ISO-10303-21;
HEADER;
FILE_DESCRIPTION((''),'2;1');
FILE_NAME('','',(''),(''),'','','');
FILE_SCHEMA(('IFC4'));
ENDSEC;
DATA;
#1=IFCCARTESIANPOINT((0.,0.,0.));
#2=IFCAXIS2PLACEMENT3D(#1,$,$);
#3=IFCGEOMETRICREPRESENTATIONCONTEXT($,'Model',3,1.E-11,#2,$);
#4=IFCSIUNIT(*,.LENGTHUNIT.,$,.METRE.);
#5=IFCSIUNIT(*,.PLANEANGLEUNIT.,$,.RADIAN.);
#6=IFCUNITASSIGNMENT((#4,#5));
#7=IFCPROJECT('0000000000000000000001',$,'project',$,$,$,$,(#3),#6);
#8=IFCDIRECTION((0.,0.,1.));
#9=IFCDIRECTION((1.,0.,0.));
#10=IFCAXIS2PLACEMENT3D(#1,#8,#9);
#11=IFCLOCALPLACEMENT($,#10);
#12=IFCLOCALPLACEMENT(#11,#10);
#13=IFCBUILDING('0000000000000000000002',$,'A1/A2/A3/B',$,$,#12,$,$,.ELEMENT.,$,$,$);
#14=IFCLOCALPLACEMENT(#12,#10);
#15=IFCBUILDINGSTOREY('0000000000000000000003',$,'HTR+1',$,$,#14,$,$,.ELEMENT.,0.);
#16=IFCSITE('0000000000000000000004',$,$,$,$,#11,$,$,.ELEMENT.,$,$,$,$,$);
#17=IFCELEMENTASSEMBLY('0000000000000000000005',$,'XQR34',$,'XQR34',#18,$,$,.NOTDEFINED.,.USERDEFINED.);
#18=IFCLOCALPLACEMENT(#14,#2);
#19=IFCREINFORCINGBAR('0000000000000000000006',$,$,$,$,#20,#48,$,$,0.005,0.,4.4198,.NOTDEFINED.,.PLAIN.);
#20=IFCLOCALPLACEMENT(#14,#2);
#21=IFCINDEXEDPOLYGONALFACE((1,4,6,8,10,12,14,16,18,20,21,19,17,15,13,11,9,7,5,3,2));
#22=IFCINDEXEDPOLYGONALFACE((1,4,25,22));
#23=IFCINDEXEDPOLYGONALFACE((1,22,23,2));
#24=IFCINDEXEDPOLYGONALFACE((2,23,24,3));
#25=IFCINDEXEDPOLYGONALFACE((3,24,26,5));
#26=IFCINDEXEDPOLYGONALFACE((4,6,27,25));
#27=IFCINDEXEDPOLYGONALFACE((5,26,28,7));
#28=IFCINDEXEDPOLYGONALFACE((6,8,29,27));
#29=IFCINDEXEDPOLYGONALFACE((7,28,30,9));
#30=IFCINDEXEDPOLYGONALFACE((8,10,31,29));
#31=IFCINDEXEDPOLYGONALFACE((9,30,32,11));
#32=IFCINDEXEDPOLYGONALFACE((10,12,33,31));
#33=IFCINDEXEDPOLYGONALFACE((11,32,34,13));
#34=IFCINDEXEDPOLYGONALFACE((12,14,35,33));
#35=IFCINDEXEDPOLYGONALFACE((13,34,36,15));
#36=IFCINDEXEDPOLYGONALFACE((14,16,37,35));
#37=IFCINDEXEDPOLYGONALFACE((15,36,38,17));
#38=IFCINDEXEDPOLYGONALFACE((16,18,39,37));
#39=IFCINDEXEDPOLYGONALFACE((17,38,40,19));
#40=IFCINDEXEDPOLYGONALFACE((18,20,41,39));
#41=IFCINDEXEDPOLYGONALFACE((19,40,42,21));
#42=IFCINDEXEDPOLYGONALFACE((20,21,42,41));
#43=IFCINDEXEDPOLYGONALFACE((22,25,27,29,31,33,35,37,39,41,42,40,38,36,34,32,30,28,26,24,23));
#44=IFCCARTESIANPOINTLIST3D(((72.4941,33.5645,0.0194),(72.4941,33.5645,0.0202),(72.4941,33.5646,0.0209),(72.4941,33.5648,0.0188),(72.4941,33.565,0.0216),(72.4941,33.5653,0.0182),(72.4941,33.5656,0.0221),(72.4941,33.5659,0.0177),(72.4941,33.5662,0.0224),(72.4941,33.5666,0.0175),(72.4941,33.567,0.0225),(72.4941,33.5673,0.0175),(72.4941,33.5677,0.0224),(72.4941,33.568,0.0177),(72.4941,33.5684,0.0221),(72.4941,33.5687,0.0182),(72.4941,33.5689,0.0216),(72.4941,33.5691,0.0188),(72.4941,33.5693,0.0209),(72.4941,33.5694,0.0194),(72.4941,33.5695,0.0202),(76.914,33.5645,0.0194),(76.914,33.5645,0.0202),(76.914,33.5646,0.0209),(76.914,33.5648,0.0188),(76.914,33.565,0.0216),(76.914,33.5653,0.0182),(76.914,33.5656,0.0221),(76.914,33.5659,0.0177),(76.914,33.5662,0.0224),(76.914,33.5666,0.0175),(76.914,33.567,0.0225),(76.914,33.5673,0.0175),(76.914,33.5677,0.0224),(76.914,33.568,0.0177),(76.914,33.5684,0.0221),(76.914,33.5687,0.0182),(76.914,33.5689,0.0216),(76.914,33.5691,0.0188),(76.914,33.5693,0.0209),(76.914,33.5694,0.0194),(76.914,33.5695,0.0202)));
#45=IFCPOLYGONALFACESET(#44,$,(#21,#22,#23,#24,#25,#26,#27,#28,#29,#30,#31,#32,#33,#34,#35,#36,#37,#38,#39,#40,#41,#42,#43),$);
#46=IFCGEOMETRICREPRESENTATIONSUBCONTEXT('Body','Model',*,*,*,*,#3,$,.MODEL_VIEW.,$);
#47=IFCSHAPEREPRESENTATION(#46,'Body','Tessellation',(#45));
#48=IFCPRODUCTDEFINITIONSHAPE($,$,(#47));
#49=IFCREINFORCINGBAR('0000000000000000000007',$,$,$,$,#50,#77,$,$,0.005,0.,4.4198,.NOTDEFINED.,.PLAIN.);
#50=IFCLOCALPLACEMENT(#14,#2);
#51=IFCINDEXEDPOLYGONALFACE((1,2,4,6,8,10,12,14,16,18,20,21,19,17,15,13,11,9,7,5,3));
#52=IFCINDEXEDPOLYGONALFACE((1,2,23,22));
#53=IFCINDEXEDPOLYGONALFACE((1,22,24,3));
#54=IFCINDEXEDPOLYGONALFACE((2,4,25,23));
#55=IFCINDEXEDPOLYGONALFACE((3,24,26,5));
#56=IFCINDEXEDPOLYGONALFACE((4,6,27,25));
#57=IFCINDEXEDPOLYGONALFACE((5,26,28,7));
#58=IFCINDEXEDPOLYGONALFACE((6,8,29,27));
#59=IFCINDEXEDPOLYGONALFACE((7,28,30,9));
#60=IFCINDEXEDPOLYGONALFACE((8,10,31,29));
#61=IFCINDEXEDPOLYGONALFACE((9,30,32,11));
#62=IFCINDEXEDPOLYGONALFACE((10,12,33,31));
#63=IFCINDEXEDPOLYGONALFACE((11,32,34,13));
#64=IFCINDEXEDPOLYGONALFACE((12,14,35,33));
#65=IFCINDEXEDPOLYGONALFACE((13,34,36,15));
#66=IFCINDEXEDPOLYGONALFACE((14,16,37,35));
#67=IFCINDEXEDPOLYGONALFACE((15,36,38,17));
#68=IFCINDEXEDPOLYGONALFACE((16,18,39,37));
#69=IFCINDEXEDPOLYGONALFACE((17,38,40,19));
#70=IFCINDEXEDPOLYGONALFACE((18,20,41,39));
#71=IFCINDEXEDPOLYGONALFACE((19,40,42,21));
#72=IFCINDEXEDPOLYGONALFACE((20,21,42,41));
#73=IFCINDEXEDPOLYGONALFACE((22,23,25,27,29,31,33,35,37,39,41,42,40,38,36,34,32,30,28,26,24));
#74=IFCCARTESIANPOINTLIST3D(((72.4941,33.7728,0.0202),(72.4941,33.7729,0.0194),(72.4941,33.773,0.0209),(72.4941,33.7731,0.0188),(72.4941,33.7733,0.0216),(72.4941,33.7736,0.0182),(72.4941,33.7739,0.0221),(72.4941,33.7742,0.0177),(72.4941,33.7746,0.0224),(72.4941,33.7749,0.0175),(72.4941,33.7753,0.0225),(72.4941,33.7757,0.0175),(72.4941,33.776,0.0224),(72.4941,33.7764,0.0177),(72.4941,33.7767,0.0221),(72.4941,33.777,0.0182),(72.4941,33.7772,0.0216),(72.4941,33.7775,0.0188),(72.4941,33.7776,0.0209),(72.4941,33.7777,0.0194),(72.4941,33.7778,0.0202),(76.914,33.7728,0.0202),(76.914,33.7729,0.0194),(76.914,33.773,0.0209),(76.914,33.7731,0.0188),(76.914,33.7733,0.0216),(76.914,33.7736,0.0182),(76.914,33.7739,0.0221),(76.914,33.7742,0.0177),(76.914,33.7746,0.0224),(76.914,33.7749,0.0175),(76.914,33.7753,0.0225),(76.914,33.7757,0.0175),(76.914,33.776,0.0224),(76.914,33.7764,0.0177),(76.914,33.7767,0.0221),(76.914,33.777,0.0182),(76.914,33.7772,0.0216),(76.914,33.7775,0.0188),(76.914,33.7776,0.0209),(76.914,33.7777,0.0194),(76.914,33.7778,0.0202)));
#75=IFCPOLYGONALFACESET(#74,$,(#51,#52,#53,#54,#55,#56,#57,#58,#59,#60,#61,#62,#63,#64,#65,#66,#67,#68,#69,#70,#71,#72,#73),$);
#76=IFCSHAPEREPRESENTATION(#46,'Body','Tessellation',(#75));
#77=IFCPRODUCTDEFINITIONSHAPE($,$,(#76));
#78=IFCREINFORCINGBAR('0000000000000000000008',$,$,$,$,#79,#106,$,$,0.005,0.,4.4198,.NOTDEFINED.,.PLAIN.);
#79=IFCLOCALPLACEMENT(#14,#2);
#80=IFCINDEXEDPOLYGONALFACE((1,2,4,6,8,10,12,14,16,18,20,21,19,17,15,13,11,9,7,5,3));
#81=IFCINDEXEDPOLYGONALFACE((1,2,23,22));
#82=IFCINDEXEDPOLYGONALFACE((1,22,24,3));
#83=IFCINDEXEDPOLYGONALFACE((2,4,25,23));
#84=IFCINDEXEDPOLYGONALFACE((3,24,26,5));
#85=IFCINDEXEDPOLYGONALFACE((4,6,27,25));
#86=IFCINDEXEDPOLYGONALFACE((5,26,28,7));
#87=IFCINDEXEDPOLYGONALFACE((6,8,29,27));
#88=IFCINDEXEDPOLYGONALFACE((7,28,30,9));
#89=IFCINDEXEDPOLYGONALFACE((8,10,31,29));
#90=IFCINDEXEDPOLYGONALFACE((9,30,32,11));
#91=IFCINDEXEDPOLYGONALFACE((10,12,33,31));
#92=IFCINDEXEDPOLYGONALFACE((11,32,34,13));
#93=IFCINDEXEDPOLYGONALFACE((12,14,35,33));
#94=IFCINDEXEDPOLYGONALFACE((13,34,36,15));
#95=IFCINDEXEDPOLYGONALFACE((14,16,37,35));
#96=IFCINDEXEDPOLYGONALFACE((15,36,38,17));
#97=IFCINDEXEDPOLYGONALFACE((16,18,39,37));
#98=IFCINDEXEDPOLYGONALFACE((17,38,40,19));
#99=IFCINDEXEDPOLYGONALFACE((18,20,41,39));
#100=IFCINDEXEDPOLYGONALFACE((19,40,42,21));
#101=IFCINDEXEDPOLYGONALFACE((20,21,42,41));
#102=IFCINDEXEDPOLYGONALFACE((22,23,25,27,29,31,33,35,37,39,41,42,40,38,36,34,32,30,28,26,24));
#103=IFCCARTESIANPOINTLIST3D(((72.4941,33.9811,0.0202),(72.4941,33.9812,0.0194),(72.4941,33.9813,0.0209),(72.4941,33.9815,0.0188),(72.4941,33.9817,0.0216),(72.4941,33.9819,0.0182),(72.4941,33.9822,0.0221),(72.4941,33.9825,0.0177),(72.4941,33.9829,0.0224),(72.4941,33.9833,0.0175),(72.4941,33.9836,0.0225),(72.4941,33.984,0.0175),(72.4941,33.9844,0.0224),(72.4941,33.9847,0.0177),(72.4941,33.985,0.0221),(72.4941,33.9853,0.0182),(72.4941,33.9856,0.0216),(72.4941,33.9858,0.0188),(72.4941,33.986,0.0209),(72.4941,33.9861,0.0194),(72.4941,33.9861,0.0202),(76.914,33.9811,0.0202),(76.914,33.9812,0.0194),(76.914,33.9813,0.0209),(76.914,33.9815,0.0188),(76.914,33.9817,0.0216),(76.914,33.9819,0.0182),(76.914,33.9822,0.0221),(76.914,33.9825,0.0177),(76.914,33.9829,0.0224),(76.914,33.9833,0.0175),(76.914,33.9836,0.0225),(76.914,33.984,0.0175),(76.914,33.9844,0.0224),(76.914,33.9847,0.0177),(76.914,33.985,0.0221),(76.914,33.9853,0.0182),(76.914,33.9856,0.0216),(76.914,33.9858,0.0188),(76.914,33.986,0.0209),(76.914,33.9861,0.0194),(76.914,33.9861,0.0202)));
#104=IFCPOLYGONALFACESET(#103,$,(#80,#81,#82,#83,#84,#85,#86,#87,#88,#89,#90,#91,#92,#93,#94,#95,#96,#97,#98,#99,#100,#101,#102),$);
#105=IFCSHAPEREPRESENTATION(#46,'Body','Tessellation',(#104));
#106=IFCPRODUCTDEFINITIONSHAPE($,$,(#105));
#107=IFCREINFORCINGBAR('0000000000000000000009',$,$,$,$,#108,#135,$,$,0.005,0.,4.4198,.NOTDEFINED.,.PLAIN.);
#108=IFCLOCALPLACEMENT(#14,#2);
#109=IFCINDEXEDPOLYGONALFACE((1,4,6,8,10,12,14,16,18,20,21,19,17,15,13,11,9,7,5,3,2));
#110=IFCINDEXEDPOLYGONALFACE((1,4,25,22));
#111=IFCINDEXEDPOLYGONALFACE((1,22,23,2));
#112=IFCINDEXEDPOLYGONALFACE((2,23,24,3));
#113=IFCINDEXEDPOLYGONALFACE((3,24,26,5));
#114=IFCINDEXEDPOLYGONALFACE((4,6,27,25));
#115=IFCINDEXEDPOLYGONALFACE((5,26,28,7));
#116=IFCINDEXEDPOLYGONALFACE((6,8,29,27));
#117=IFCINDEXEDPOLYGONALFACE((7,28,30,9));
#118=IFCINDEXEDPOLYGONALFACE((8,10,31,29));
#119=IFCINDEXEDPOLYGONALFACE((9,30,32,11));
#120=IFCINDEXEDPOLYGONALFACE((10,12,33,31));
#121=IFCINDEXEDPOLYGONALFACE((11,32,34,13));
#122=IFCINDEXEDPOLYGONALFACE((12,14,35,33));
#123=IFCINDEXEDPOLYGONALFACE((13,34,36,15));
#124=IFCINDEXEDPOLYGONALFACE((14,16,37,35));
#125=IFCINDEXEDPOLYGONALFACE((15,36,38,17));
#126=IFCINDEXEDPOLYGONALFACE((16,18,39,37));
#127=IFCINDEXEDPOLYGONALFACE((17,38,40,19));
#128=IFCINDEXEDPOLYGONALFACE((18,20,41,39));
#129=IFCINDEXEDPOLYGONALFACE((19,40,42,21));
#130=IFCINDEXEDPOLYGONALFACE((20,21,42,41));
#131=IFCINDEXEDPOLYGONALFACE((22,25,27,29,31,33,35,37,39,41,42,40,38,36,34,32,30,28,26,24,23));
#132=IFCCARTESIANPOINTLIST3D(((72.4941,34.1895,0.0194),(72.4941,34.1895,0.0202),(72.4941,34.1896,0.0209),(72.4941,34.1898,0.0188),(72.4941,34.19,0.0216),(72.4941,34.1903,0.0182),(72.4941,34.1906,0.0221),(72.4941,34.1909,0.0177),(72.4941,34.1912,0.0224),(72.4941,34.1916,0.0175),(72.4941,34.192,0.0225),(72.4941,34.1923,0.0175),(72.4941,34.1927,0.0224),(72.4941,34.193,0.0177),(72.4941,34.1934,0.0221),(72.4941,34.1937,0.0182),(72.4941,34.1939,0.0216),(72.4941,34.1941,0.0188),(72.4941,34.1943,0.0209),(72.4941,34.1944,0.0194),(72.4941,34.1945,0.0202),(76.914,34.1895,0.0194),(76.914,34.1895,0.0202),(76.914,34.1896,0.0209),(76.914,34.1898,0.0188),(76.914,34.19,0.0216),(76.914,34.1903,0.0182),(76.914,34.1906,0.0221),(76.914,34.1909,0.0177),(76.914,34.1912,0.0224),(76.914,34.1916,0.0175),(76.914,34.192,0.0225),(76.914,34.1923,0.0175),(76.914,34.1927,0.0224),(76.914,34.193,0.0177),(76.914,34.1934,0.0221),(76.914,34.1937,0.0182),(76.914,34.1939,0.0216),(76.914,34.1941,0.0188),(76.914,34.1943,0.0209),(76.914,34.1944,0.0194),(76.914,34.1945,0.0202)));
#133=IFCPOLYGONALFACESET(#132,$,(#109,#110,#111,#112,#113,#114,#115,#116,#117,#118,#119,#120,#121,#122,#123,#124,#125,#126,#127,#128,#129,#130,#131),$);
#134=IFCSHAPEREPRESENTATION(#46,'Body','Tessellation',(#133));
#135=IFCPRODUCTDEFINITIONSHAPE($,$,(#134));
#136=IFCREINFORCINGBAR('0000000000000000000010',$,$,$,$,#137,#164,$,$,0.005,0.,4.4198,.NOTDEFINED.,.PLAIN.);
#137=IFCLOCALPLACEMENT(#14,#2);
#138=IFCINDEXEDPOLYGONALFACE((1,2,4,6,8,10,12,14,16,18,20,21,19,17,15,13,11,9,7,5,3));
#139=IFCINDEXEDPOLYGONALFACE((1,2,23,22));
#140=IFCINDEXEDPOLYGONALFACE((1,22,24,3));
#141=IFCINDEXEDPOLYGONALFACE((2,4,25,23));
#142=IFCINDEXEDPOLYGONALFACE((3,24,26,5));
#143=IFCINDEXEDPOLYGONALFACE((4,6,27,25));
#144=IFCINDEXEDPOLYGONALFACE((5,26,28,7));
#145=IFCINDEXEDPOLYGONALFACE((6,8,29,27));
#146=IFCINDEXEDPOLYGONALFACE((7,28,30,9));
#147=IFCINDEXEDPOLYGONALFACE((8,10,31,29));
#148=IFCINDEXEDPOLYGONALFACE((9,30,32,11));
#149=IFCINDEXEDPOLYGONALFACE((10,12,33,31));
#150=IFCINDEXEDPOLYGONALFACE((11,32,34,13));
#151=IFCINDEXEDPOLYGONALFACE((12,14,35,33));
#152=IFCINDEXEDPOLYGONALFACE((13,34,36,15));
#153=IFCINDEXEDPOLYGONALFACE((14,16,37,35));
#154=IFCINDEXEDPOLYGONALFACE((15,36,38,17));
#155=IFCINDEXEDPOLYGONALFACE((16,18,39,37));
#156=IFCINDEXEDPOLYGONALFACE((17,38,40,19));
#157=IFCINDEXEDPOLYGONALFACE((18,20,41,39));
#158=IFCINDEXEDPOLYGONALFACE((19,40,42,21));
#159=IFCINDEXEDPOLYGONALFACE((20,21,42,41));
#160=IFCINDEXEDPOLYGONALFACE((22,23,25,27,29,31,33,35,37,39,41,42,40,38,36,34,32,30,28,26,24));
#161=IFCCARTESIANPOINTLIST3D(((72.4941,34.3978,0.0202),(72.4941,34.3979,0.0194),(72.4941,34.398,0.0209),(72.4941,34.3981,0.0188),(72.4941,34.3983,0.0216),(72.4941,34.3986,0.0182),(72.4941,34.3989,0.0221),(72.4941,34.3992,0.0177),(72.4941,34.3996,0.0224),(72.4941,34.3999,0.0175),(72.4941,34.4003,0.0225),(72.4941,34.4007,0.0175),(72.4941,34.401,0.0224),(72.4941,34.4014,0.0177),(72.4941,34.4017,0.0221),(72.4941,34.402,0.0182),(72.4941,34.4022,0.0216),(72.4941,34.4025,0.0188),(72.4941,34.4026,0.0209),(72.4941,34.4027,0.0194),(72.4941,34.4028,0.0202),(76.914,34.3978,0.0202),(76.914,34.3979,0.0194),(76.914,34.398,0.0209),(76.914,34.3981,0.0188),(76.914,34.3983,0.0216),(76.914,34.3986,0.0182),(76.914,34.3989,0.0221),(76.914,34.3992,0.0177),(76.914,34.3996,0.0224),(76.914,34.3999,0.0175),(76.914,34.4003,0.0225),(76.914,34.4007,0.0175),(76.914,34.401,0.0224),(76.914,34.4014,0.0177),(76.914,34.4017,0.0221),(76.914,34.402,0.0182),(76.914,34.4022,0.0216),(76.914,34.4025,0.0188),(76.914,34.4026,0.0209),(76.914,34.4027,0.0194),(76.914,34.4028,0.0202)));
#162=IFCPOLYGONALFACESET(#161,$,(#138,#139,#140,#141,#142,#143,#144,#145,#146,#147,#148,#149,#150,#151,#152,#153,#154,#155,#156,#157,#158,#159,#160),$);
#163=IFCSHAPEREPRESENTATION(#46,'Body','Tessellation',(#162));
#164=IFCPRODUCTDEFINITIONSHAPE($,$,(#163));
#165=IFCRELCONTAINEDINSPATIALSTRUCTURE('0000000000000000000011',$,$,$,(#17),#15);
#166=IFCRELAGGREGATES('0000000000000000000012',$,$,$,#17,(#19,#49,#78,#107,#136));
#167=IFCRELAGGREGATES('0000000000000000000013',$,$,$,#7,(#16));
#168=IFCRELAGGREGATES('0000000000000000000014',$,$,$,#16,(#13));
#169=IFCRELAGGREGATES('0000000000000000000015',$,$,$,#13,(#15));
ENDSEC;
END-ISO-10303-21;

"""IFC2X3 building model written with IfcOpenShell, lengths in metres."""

from ifc_helpers import new_model, entity, si_unit, origin, origin_with_axes, place, context, subcontext, project, spatial, shape, element, aggregate, save


model = new_model("IFC2X3")

# Units and contexts
model_context = context("Model", 3, precision=1e-11, world=origin())
body_context = subcontext(model_context, "Body", "Model", "MODEL_VIEW")
ifc_project = project(units=[si_unit("LENGTHUNIT", "METRE"), si_unit("PLANEANGLEUNIT", "RADIAN")], contexts=[model_context])

# Site, building, storey
site_placement = place(None, origin_with_axes())
site = spatial("IfcSite", under=ifc_project, at=site_placement, CompositionType="ELEMENT")
building_placement = place(site_placement, origin_with_axes())
building = spatial("IfcBuilding", under=site, at=building_placement, Name="A1/A2/A3/B", CompositionType="ELEMENT")
storey_placement = place(building_placement, origin_with_axes())
storey = spatial("IfcBuildingStorey", under=building, at=storey_placement, Name="HTR+1", CompositionType="ELEMENT", Elevation=0.0)

# Element assembly, reinforcing bars
assembly_1_placement = place(storey_placement, origin_with_axes())
assembly_1 = element("IfcElementAssembly", 1, at=assembly_1_placement, inside=storey, Name="XQR34", ObjectType="XQR34", AssemblyPlace="NOTDEFINED", PredefinedType="USERDEFINED")
reinforcing_bar_1_placement = place(assembly_1_placement, origin_with_axes())
reinforcing_bar_1 = element("IfcReinforcingBar", 2, at=reinforcing_bar_1_placement, BarLength=4.4198, BarRole="NOTDEFINED", BarSurface="PLAIN", CrossSectionArea=0.0, NominalDiameter=0.005, shapes=[
    shape(body_context, "Body", "AdvancedSweptSolid", [entity("IfcSweptDiskSolid", entity("IfcPolyline", [entity("IfcCartesianPoint", [72.4941, 33.567, 0.02]), entity("IfcCartesianPoint", [76.914, 33.567, 0.02])]), 0.0025, None, 0.0, 4.4198)]),
    shape(body_context, "Body", "AdvancedSweptSolid", [entity("IfcSweptDiskSolid", entity("IfcPolyline", [entity("IfcCartesianPoint", [72.4941, 33.567, 0.02]), entity("IfcCartesianPoint", [76.914, 33.567, 0.02])]), 0.0025, None, 0.0, 4.4198)]),
])
reinforcing_bar_2_placement = place(assembly_1_placement, origin_with_axes())
reinforcing_bar_2 = element("IfcReinforcingBar", 3, at=reinforcing_bar_2_placement, BarLength=4.4198, BarRole="NOTDEFINED", BarSurface="PLAIN", CrossSectionArea=0.0, NominalDiameter=0.005, shapes=[
    shape(body_context, "Body", "AdvancedSweptSolid", [entity("IfcSweptDiskSolid", entity("IfcPolyline", [entity("IfcCartesianPoint", [72.4941, 33.7753, 0.02]), entity("IfcCartesianPoint", [76.914, 33.7753, 0.02])]), 0.0025, None, 0.0, 4.4198)]),
    shape(body_context, "Body", "AdvancedSweptSolid", [entity("IfcSweptDiskSolid", entity("IfcPolyline", [entity("IfcCartesianPoint", [72.4941, 33.7753, 0.02]), entity("IfcCartesianPoint", [76.914, 33.7753, 0.02])]), 0.0025, None, 0.0, 4.4198)]),
])
reinforcing_bar_3_placement = place(assembly_1_placement, origin_with_axes())
reinforcing_bar_3 = element("IfcReinforcingBar", 4, at=reinforcing_bar_3_placement, BarLength=4.4198, BarRole="NOTDEFINED", BarSurface="PLAIN", CrossSectionArea=0.0, NominalDiameter=0.005, shapes=[
    shape(body_context, "Body", "AdvancedSweptSolid", [entity("IfcSweptDiskSolid", entity("IfcPolyline", [entity("IfcCartesianPoint", [72.4941, 33.9836, 0.02]), entity("IfcCartesianPoint", [76.914, 33.9836, 0.02])]), 0.0025, None, 0.0, 4.4198)]),
    shape(body_context, "Body", "AdvancedSweptSolid", [entity("IfcSweptDiskSolid", entity("IfcPolyline", [entity("IfcCartesianPoint", [72.4941, 33.9836, 0.02]), entity("IfcCartesianPoint", [76.914, 33.9836, 0.02])]), 0.0025, None, 0.0, 4.4198)]),
])
reinforcing_bar_4_placement = place(assembly_1_placement, origin_with_axes())
reinforcing_bar_4 = element("IfcReinforcingBar", 5, at=reinforcing_bar_4_placement, BarLength=4.4198, BarRole="NOTDEFINED", BarSurface="PLAIN", CrossSectionArea=0.0, NominalDiameter=0.005, shapes=[
    shape(body_context, "Body", "AdvancedSweptSolid", [entity("IfcSweptDiskSolid", entity("IfcPolyline", [entity("IfcCartesianPoint", [72.4941, 34.192, 0.02]), entity("IfcCartesianPoint", [76.914, 34.192, 0.02])]), 0.0025, None, 0.0, 4.4198)]),
    shape(body_context, "Body", "AdvancedSweptSolid", [entity("IfcSweptDiskSolid", entity("IfcPolyline", [entity("IfcCartesianPoint", [72.4941, 34.192, 0.02]), entity("IfcCartesianPoint", [76.914, 34.192, 0.02])]), 0.0025, None, 0.0, 4.4198)]),
])
reinforcing_bar_5_placement = place(assembly_1_placement, origin_with_axes())
reinforcing_bar_5 = element("IfcReinforcingBar", 6, at=reinforcing_bar_5_placement, BarLength=4.4198, BarRole="NOTDEFINED", BarSurface="PLAIN", CrossSectionArea=0.0, NominalDiameter=0.005, shapes=[
    shape(body_context, "Body", "AdvancedSweptSolid", [entity("IfcSweptDiskSolid", entity("IfcPolyline", [entity("IfcCartesianPoint", [72.4941, 34.4003, 0.02]), entity("IfcCartesianPoint", [76.914, 34.4003, 0.02])]), 0.0025, None, 0.0, 4.4198)]),
    shape(body_context, "Body", "AdvancedSweptSolid", [entity("IfcSweptDiskSolid", entity("IfcPolyline", [entity("IfcCartesianPoint", [72.4941, 34.4003, 0.02]), entity("IfcCartesianPoint", [76.914, 34.4003, 0.02])]), 0.0025, None, 0.0, 4.4198)]),
])
aggregate(assembly_1, [reinforcing_bar_1, reinforcing_bar_2, reinforcing_bar_3, reinforcing_bar_4, reinforcing_bar_5])

save(model, "model.ifc")
